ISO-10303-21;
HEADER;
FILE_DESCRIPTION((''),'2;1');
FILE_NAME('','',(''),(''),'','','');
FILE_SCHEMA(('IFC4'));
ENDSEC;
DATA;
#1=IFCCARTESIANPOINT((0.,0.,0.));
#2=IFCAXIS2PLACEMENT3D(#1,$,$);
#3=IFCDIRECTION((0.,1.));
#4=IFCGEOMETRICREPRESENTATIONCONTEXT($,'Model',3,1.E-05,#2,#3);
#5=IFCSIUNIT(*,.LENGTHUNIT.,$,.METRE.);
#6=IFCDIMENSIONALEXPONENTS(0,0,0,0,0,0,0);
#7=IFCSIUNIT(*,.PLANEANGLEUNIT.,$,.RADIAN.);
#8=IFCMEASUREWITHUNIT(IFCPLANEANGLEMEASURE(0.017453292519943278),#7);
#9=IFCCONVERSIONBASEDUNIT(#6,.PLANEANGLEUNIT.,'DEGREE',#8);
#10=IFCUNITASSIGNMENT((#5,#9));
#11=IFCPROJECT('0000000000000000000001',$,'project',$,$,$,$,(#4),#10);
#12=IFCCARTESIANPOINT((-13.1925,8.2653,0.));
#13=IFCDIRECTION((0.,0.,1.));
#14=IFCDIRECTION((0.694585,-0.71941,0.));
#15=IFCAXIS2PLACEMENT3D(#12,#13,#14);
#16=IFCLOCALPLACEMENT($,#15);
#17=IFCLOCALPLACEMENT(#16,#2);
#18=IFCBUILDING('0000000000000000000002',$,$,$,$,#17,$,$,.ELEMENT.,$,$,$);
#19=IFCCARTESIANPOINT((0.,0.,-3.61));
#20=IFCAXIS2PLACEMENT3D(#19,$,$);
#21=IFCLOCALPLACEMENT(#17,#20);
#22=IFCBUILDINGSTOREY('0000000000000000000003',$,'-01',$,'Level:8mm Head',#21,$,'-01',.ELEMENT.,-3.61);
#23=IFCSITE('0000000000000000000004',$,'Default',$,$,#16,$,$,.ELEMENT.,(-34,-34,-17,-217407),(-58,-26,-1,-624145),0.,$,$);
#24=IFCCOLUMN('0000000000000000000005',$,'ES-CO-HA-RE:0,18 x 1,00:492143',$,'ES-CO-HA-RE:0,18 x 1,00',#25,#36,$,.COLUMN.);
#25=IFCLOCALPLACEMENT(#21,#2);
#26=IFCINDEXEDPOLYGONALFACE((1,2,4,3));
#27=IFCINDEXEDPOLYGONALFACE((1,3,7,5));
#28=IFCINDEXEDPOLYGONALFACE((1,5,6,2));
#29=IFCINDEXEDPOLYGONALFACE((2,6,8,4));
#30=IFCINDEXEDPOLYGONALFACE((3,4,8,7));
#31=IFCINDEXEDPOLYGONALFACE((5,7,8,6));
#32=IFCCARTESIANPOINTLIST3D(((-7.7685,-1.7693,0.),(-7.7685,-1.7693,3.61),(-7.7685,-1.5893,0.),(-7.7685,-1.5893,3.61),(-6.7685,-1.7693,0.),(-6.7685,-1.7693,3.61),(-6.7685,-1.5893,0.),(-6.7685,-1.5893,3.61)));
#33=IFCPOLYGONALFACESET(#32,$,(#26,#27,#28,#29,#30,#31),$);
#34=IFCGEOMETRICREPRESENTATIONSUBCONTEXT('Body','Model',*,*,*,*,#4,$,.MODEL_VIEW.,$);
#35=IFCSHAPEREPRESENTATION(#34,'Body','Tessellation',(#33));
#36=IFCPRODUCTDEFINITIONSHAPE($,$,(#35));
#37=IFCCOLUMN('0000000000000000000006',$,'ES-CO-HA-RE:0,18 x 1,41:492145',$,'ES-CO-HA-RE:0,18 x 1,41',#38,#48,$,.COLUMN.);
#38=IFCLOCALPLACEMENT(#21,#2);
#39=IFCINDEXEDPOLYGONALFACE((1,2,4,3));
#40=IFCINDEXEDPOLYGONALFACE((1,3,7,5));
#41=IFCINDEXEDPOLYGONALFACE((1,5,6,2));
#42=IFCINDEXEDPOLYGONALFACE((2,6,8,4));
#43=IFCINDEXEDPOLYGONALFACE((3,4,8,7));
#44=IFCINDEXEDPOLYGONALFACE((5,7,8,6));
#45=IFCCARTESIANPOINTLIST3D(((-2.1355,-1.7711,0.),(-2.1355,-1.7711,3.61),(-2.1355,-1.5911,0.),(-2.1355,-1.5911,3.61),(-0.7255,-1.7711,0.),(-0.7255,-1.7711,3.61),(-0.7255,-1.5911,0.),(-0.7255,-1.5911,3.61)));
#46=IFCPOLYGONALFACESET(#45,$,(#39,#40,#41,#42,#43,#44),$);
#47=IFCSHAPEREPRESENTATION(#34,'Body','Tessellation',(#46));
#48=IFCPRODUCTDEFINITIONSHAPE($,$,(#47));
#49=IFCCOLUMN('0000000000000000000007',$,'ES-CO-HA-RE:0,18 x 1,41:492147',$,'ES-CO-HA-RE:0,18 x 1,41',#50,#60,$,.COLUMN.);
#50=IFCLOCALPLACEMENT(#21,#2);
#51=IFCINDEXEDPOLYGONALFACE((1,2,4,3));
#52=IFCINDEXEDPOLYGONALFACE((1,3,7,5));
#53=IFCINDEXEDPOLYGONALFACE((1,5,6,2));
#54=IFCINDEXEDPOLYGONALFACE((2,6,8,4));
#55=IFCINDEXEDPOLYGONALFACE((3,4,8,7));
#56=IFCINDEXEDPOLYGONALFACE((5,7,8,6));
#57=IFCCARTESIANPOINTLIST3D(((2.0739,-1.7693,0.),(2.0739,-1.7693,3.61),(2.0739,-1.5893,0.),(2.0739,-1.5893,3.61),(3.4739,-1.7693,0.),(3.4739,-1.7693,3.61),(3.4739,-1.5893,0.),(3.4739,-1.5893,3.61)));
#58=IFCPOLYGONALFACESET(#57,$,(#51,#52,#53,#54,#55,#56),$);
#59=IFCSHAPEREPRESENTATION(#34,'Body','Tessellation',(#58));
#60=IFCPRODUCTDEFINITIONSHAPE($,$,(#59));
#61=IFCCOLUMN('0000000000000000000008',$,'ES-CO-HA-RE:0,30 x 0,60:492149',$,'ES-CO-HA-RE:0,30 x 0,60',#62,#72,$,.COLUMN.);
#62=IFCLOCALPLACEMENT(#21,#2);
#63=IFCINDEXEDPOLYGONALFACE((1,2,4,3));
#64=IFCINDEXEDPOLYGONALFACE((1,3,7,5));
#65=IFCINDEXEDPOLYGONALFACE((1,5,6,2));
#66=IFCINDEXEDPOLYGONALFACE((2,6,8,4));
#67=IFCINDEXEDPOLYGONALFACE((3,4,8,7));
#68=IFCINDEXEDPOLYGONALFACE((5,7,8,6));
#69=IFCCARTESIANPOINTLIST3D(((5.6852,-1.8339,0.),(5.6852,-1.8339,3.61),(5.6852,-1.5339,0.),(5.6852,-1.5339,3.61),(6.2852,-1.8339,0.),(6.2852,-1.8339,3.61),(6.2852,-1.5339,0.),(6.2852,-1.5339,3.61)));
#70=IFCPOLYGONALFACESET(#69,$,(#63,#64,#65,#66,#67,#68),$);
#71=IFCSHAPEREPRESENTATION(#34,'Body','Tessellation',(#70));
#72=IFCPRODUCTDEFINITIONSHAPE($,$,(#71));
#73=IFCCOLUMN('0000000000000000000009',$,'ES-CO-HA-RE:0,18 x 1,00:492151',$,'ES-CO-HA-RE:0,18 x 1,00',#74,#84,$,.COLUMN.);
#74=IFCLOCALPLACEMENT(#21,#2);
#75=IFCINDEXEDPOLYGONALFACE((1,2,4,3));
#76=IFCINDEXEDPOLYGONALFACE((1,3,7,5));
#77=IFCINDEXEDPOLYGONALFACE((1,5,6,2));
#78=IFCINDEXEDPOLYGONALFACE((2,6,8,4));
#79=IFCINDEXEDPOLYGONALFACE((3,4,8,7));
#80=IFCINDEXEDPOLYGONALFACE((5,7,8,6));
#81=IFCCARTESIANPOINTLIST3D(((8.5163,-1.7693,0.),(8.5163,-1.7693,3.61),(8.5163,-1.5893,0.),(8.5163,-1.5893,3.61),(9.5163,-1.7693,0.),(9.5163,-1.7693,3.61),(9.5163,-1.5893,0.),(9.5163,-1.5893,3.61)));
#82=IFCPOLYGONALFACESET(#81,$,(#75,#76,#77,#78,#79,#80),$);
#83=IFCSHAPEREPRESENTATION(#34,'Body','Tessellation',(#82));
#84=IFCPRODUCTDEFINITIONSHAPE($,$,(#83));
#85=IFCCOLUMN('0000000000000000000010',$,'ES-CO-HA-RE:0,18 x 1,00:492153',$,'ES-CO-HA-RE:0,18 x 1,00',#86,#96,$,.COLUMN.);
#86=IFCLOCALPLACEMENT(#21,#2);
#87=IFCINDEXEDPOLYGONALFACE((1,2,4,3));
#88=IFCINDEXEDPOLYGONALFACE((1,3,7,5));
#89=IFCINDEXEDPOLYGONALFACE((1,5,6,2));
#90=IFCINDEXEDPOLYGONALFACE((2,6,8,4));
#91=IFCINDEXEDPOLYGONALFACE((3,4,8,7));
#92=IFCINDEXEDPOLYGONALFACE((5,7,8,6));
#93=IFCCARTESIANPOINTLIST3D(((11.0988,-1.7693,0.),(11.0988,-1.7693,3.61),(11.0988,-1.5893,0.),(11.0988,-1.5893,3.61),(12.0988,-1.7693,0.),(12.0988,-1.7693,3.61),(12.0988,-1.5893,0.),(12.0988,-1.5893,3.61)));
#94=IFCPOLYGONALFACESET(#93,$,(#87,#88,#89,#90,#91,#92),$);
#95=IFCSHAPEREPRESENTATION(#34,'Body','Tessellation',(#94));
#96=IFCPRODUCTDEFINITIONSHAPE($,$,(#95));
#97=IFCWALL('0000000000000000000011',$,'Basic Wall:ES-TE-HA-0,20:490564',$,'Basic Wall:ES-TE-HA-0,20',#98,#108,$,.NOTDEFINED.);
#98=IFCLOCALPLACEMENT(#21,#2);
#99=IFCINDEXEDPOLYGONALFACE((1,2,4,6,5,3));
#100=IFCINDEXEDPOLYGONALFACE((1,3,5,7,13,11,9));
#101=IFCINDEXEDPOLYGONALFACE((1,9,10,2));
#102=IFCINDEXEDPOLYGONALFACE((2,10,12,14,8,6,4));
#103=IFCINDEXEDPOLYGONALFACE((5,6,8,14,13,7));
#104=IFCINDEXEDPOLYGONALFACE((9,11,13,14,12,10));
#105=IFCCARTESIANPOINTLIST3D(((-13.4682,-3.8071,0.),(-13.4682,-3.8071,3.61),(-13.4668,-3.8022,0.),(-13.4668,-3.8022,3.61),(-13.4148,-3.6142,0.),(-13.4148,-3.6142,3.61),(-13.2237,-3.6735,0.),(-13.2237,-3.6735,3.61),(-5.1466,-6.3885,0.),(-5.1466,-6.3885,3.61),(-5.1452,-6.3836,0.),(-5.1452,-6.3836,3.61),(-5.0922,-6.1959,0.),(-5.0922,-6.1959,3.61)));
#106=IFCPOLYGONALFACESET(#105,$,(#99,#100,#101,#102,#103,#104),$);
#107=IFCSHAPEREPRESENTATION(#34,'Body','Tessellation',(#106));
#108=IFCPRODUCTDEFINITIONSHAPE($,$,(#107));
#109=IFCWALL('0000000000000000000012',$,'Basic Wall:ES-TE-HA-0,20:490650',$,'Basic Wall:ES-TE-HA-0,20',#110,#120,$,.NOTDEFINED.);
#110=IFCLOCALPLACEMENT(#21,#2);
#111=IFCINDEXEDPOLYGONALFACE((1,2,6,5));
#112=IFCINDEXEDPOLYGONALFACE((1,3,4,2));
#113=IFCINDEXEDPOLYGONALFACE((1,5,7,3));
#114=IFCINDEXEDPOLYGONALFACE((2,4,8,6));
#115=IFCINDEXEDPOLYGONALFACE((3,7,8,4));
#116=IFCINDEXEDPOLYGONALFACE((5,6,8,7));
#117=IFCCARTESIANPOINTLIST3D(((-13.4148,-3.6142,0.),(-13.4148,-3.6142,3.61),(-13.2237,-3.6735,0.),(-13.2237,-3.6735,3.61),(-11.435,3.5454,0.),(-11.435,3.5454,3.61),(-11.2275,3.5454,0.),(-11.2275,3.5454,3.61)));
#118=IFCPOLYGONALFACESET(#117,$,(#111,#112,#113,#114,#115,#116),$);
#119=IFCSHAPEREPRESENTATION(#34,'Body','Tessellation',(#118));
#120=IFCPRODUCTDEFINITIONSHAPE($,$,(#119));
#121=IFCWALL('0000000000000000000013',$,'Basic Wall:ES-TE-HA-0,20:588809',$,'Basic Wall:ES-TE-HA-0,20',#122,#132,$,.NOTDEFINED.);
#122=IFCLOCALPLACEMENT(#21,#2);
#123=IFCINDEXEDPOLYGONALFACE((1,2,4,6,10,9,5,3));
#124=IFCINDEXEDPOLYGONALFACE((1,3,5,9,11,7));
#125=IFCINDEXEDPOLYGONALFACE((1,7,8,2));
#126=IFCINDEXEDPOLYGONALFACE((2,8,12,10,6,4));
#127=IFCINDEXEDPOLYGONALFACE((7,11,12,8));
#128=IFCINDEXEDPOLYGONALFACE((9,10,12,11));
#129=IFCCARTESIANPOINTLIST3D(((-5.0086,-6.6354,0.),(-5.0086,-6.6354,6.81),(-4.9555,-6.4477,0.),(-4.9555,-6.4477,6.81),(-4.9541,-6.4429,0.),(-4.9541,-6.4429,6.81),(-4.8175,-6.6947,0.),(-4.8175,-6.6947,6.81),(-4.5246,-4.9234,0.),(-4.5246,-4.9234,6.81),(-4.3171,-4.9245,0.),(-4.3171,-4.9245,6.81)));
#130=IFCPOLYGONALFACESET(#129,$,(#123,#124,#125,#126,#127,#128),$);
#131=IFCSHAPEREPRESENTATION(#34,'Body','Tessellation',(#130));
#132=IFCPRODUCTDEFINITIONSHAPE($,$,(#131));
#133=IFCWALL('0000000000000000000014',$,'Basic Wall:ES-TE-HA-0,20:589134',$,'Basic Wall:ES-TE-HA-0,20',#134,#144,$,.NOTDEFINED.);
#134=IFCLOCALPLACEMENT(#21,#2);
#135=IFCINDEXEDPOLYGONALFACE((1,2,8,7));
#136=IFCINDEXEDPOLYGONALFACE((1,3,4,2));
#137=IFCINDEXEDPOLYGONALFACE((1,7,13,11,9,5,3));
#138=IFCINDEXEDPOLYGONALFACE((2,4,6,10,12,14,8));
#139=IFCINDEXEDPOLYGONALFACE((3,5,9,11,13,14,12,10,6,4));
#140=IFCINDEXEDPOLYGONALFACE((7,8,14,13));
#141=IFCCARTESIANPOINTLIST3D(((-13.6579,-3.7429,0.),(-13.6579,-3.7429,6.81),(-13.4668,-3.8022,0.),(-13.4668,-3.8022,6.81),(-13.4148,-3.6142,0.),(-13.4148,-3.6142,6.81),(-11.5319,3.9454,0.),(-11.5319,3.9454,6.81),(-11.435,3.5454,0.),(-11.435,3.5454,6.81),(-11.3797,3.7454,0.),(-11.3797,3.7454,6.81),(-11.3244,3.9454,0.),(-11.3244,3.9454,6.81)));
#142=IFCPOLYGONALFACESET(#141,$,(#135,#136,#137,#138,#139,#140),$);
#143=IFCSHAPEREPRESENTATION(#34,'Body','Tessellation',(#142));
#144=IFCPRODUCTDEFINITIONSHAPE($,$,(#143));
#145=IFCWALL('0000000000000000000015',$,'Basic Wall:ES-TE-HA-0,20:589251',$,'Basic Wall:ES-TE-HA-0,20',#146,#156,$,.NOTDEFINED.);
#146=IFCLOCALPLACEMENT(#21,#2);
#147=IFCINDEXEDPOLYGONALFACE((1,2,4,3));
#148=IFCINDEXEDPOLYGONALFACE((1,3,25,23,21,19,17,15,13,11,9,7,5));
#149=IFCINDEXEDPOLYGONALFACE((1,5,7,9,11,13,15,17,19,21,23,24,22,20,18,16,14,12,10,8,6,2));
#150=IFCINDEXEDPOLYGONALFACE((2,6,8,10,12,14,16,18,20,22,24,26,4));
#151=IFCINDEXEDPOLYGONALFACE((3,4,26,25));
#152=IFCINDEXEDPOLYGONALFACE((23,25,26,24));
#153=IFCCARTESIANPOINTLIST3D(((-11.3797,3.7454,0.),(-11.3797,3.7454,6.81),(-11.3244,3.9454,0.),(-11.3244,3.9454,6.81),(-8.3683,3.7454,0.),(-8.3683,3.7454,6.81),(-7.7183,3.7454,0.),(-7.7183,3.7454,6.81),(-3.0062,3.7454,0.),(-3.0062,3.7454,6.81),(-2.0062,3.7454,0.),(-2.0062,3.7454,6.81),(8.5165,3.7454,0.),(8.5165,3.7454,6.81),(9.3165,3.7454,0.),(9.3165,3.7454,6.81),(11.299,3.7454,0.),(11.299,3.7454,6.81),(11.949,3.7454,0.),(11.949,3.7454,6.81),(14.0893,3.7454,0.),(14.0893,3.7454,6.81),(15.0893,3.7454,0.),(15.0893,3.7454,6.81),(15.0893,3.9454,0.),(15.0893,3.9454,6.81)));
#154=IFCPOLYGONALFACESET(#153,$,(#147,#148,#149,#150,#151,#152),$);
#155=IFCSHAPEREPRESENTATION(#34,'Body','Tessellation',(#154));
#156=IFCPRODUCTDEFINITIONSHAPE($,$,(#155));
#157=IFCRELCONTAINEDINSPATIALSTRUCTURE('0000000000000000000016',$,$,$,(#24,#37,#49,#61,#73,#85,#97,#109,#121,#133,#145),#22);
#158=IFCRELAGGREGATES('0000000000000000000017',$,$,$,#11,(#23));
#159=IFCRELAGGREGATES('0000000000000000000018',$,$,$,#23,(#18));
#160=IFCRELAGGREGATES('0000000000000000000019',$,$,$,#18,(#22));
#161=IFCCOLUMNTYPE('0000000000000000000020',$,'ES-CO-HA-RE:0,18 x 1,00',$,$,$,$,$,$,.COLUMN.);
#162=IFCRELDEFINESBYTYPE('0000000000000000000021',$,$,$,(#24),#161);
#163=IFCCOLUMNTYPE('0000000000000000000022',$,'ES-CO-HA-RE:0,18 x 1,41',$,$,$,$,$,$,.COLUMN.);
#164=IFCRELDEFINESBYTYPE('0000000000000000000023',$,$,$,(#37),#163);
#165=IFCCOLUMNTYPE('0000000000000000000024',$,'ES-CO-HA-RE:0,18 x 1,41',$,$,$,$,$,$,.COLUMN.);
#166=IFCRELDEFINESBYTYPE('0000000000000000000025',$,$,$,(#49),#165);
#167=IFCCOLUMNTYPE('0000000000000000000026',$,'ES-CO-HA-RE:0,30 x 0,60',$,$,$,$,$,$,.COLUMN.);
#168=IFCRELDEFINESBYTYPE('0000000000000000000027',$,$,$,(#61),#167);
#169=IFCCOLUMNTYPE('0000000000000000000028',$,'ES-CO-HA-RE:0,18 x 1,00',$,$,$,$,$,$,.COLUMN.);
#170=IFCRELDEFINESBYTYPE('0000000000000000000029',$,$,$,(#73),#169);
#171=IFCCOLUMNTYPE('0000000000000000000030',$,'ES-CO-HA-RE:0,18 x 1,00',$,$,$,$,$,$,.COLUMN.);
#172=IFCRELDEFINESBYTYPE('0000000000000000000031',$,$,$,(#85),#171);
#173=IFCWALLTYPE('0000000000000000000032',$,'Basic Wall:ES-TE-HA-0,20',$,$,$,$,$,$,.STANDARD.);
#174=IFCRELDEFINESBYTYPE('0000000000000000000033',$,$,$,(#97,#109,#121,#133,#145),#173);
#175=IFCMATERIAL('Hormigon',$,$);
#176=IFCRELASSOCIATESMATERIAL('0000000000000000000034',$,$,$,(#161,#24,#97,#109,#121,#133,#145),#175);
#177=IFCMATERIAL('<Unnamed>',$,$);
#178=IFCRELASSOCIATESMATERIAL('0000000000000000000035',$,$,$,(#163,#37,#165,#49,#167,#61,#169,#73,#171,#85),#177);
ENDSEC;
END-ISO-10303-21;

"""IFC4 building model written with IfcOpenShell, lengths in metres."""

from ifc_helpers import new_model, entity, si_unit, converted_unit, direction, frame, origin, place, context, subcontext, project, spatial, indexed_curve, outline, extrude, source, transform, mapped, material, type_object, type_shapes, element, save


model = new_model("IFC4")

# Units and contexts
model_context = context("Model", 3, precision=1e-05, world=origin(), true_north=direction((0.0, 1.0)))
body_context = subcontext(model_context, "Body", "Model", "MODEL_VIEW")
ifc_project = project(units=[si_unit("LENGTHUNIT", "METRE"), converted_unit("PLANEANGLEUNIT", "DEGREE", entity("IfcPlaneAngleMeasure", 0.017453292519943278), si_unit("PLANEANGLEUNIT", "RADIAN"), dimensions=[0, 0, 0, 0, 0, 0, 0])], contexts=[model_context])

# Site, building, storey
site_placement = place(None, frame((-13.1925, 8.2653, 0.0), z_axis=(0.0, 0.0, 1.0), x_axis=(0.694585, -0.71941, 0.0)))
site = spatial("IfcSite", under=ifc_project, at=site_placement, Name="Default", CompositionType="ELEMENT", RefLatitude=(-34, -34, -17, -217407), RefLongitude=(-58, -26, -1, -624145), RefElevation=0.0)
building_placement = place(site_placement, origin())
building = spatial("IfcBuilding", under=site, at=building_placement, CompositionType="ELEMENT")
storey_placement = place(building_placement, frame((0.0, 0.0, -3.61)))
storey = spatial("IfcBuildingStorey", under=building, at=storey_placement, Name="-01", ObjectType="Level:8mm Head", LongName="-01", CompositionType="ELEMENT", Elevation=-3.61)

# Columns
ifc_material_1 = material(Name="<Unnamed>")
ifc_material_2 = material(Name="Hormigon")
column_type_1 = type_object("IfcColumnType", Name="ES-CO-HA-RE:0,18 x 1,00", PredefinedType="COLUMN", material=ifc_material_2)
shared_shape_1 = source(origin(), body_context, "Body", "SweptSolid", [
    extrude(outline(indexed_curve([(-0.5, -0.09), (0.5, -0.09), (0.5, 0.09), (-0.5, 0.09), (-0.5, -0.09)], self_intersect=False)), frame((-7.2685, -1.6793, -3.61), z_axis=(0.0, 0.0, 1.0), x_axis=(-1.0, 0.0, 0.0)), (0.0, 0.0, 1.0), 3.61),
])
type_shapes(column_type_1, [shared_shape_1])
column_1_placement = place(storey_placement, frame((0.0, 0.0, 3.61)))
element("IfcColumn", 1, at=column_1_placement, inside=storey, type_object=column_type_1, material=ifc_material_2, Name="ES-CO-HA-RE:0,18 x 1,00:492143", ObjectType="ES-CO-HA-RE:0,18 x 1,00", PredefinedType="COLUMN", context=body_context, shape_type="MappedRepresentation", body=[
    mapped(shared_shape_1, transform((0.0, 0.0, 0.0), scale=1.0)),
])
column_type_2 = type_object("IfcColumnType", Name="ES-CO-HA-RE:0,18 x 1,41", PredefinedType="COLUMN", material=ifc_material_1)
shared_shape_2 = source(origin(), body_context, "Body", "SweptSolid", [
    extrude(outline(indexed_curve([(-0.705, -0.09), (0.705, -0.09), (0.705, 0.09), (-0.705, 0.09), (-0.705, -0.09)], self_intersect=False)), frame((-1.4305, -1.6811, -3.61), z_axis=(0.0, 0.0, 1.0), x_axis=(-1.0, 0.0, 0.0)), (0.0, 0.0, 1.0), 3.61),
])
type_shapes(column_type_2, [shared_shape_2])
column_2_placement = place(storey_placement, frame((0.0, 0.0, 3.61)))
element("IfcColumn", 2, at=column_2_placement, inside=storey, type_object=column_type_2, material=ifc_material_1, Name="ES-CO-HA-RE:0,18 x 1,41:492145", ObjectType="ES-CO-HA-RE:0,18 x 1,41", PredefinedType="COLUMN", context=body_context, shape_type="MappedRepresentation", body=[
    mapped(shared_shape_2, transform((0.0, 0.0, 0.0), scale=1.0)),
])
column_type_3 = type_object("IfcColumnType", Name="ES-CO-HA-RE:0,18 x 1,41", PredefinedType="COLUMN", material=ifc_material_1)
shared_shape_3 = source(origin(), body_context, "Body", "SweptSolid", [
    extrude(outline(indexed_curve([(-0.7, -0.09), (0.7, -0.09), (0.7, 0.09), (-0.7, 0.09), (-0.7, -0.09)], self_intersect=False)), frame((2.7739, -1.6793, -3.61), z_axis=(0.0, 0.0, 1.0), x_axis=(-1.0, 0.0, 0.0)), (0.0, 0.0, 1.0), 3.61),
])
type_shapes(column_type_3, [shared_shape_3])
column_3_placement = place(storey_placement, frame((0.0, 0.0, 3.61)))
element("IfcColumn", 3, at=column_3_placement, inside=storey, type_object=column_type_3, material=ifc_material_1, Name="ES-CO-HA-RE:0,18 x 1,41:492147", ObjectType="ES-CO-HA-RE:0,18 x 1,41", PredefinedType="COLUMN", context=body_context, shape_type="MappedRepresentation", body=[
    mapped(shared_shape_3, transform((0.0, 0.0, 0.0), scale=1.0)),
])
column_type_4 = type_object("IfcColumnType", Name="ES-CO-HA-RE:0,30 x 0,60", PredefinedType="COLUMN", material=ifc_material_1)
shared_shape_4 = source(origin(), body_context, "Body", "SweptSolid", [
    extrude(outline(indexed_curve([(-0.3, -0.15), (0.3, -0.15), (0.3, 0.15), (-0.3, 0.15), (-0.3, -0.15)], self_intersect=False)), frame((5.9852, -1.6839, -3.61), z_axis=(0.0, 0.0, 1.0), x_axis=(-1.0, 0.0, 0.0)), (0.0, 0.0, 1.0), 3.61),
])
type_shapes(column_type_4, [shared_shape_4])
column_4_placement = place(storey_placement, frame((0.0, 0.0, 3.61)))
element("IfcColumn", 4, at=column_4_placement, inside=storey, type_object=column_type_4, material=ifc_material_1, Name="ES-CO-HA-RE:0,30 x 0,60:492149", ObjectType="ES-CO-HA-RE:0,30 x 0,60", PredefinedType="COLUMN", context=body_context, shape_type="MappedRepresentation", body=[
    mapped(shared_shape_4, transform((0.0, 0.0, 0.0), scale=1.0)),
])
column_type_5 = type_object("IfcColumnType", Name="ES-CO-HA-RE:0,18 x 1,00", PredefinedType="COLUMN", material=ifc_material_1)
shared_shape_5 = source(origin(), body_context, "Body", "SweptSolid", [
    extrude(outline(indexed_curve([(-0.5, -0.09), (0.5, -0.09), (0.5, 0.09), (-0.5, 0.09), (-0.5, -0.09)], self_intersect=False)), frame((9.0163, -1.6793, -3.61), z_axis=(0.0, 0.0, 1.0), x_axis=(-1.0, 0.0, 0.0)), (0.0, 0.0, 1.0), 3.61),
])
type_shapes(column_type_5, [shared_shape_5])
column_5_placement = place(storey_placement, frame((0.0, 0.0, 3.61)))
element("IfcColumn", 5, at=column_5_placement, inside=storey, type_object=column_type_5, material=ifc_material_1, Name="ES-CO-HA-RE:0,18 x 1,00:492151", ObjectType="ES-CO-HA-RE:0,18 x 1,00", PredefinedType="COLUMN", context=body_context, shape_type="MappedRepresentation", body=[
    mapped(shared_shape_5, transform((0.0, 0.0, 0.0), scale=1.0)),
])
column_type_6 = type_object("IfcColumnType", Name="ES-CO-HA-RE:0,18 x 1,00", PredefinedType="COLUMN", material=ifc_material_1)
shared_shape_6 = source(origin(), body_context, "Body", "SweptSolid", [
    extrude(outline(indexed_curve([(-0.5, -0.09), (0.5, -0.09), (0.5, 0.09), (-0.5, 0.09), (-0.5, -0.09)], self_intersect=False)), frame((11.5988, -1.6793, -3.61), z_axis=(0.0, 0.0, 1.0), x_axis=(-1.0, 0.0, 0.0)), (0.0, 0.0, 1.0), 3.61),
])
type_shapes(column_type_6, [shared_shape_6])
column_6_placement = place(storey_placement, frame((0.0, 0.0, 3.61)))
element("IfcColumn", 6, at=column_6_placement, inside=storey, type_object=column_type_6, material=ifc_material_1, Name="ES-CO-HA-RE:0,18 x 1,00:492153", ObjectType="ES-CO-HA-RE:0,18 x 1,00", PredefinedType="COLUMN", context=body_context, shape_type="MappedRepresentation", body=[
    mapped(shared_shape_6, transform((0.0, 0.0, 0.0), scale=1.0)),
])

# Walls
wall_type = type_object("IfcWallType", Name="Basic Wall:ES-TE-HA-0,20", PredefinedType="STANDARD")
wall_1_placement = place(storey_placement, frame((-5.117, -6.293, 0.0), z_axis=(0.0, 0.0, 1.0), x_axis=(-0.955102, 0.296279, 0.0)))
element("IfcWall", 7, at=wall_1_placement, inside=storey, type_object=wall_type, material=ifc_material_2, Name="Basic Wall:ES-TE-HA-0,20:490564", ObjectType="Basic Wall:ES-TE-HA-0,20", PredefinedType="NOTDEFINED", context=body_context, shape_type="SweptSolid", body=[
    extrude(outline(indexed_curve([(8.719, -0.1), (8.7129, 0.0949), (8.7128, 0.1), (0.0, 0.1), (0.0001, 0.0949), (0.0051, -0.1), (8.5189, -0.1), (8.719, -0.1)], self_intersect=False)), origin(), (0.0, 0.0, 1.0), 3.61),
])
wall_2_placement = place(storey_placement, frame((-13.3201, -3.6468, 0.0), z_axis=(0.0, 0.0, 1.0), x_axis=(0.266529, 0.963827, 0.0)))
element("IfcWall", 8, at=wall_2_placement, inside=storey, type_object=wall_type, material=ifc_material_2, Name="Basic Wall:ES-TE-HA-0,20:490650", ObjectType="Basic Wall:ES-TE-HA-0,20", PredefinedType="NOTDEFINED", context=body_context, shape_type="SweptSolid", body=[
    extrude(outline(indexed_curve([(7.4899, -0.1), (7.4345, 0.1), (0.0062, 0.1), (0.0, -0.1), (7.4899, -0.1)], self_intersect=False)), origin(), (0.0, 0.0, 1.0), 3.61),
])
wall_3_placement = place(storey_placement, frame((-4.4133, -4.8973, 0.0), z_axis=(0.0, 0.0, 1.0), x_axis=(-0.272019, -0.962292, 0.0)))
element("IfcWall", 9, at=wall_3_placement, inside=storey, type_object=wall_type, material=ifc_material_2, Name="Basic Wall:ES-TE-HA-0,20:588809", ObjectType="Basic Wall:ES-TE-HA-0,20", PredefinedType="NOTDEFINED", context=body_context, shape_type="SweptSolid", body=[
    extrude(outline(indexed_curve([(0.0, 0.1), (0.0553, -0.1), (1.6344, -0.1), (1.6394, -0.1), (1.8344, -0.1), (1.8395, 0.1), (0.0, 0.1)], self_intersect=False)), origin(), (0.0, 0.0, 1.0), 6.81),
])
wall_4_placement = place(storey_placement, frame((-13.5632, -3.7755, 0.0), z_axis=(0.0, 0.0, 1.0), x_axis=(0.266529, 0.963827, 0.0)))
element("IfcWall", 10, at=wall_4_placement, inside=storey, type_object=wall_type, material=ifc_material_2, Name="Basic Wall:ES-TE-HA-0,20:589134", ObjectType="Basic Wall:ES-TE-HA-0,20", PredefinedType="NOTDEFINED", context=body_context, shape_type="SweptSolid", body=[
    extrude(outline(indexed_curve([(8.0384, -0.1), (7.9831, 0.1), (0.0062, 0.1), (0.0, -0.1), (0.195, -0.1), (7.6234, -0.1), (7.8309, -0.1), (8.0384, -0.1)], self_intersect=False)), origin(), (0.0, 0.0, 1.0), 6.81),
])
wall_5_placement = place(storey_placement, frame((-11.3797, 3.8454, 0.0)))
element("IfcWall", 11, at=wall_5_placement, inside=storey, type_object=wall_type, material=ifc_material_2, Name="Basic Wall:ES-TE-HA-0,20:589251", ObjectType="Basic Wall:ES-TE-HA-0,20", PredefinedType="NOTDEFINED", context=body_context, shape_type="SweptSolid", body=[
    extrude(outline(indexed_curve([(26.469, -0.1), (26.469, 0.1), (0.0553, 0.1), (0.0, -0.1), (3.0114, -0.1), (3.6614, -0.1), (8.3734, -0.1), (9.3734, -0.1), (19.8962, -0.1), (20.6962, -0.1), (22.6787, -0.1), (23.3287, -0.1), (25.469, -0.1), (26.469, -0.1)], self_intersect=False)), origin(), (0.0, 0.0, 1.0), 6.81),
])

save(model, "model.ifc")
